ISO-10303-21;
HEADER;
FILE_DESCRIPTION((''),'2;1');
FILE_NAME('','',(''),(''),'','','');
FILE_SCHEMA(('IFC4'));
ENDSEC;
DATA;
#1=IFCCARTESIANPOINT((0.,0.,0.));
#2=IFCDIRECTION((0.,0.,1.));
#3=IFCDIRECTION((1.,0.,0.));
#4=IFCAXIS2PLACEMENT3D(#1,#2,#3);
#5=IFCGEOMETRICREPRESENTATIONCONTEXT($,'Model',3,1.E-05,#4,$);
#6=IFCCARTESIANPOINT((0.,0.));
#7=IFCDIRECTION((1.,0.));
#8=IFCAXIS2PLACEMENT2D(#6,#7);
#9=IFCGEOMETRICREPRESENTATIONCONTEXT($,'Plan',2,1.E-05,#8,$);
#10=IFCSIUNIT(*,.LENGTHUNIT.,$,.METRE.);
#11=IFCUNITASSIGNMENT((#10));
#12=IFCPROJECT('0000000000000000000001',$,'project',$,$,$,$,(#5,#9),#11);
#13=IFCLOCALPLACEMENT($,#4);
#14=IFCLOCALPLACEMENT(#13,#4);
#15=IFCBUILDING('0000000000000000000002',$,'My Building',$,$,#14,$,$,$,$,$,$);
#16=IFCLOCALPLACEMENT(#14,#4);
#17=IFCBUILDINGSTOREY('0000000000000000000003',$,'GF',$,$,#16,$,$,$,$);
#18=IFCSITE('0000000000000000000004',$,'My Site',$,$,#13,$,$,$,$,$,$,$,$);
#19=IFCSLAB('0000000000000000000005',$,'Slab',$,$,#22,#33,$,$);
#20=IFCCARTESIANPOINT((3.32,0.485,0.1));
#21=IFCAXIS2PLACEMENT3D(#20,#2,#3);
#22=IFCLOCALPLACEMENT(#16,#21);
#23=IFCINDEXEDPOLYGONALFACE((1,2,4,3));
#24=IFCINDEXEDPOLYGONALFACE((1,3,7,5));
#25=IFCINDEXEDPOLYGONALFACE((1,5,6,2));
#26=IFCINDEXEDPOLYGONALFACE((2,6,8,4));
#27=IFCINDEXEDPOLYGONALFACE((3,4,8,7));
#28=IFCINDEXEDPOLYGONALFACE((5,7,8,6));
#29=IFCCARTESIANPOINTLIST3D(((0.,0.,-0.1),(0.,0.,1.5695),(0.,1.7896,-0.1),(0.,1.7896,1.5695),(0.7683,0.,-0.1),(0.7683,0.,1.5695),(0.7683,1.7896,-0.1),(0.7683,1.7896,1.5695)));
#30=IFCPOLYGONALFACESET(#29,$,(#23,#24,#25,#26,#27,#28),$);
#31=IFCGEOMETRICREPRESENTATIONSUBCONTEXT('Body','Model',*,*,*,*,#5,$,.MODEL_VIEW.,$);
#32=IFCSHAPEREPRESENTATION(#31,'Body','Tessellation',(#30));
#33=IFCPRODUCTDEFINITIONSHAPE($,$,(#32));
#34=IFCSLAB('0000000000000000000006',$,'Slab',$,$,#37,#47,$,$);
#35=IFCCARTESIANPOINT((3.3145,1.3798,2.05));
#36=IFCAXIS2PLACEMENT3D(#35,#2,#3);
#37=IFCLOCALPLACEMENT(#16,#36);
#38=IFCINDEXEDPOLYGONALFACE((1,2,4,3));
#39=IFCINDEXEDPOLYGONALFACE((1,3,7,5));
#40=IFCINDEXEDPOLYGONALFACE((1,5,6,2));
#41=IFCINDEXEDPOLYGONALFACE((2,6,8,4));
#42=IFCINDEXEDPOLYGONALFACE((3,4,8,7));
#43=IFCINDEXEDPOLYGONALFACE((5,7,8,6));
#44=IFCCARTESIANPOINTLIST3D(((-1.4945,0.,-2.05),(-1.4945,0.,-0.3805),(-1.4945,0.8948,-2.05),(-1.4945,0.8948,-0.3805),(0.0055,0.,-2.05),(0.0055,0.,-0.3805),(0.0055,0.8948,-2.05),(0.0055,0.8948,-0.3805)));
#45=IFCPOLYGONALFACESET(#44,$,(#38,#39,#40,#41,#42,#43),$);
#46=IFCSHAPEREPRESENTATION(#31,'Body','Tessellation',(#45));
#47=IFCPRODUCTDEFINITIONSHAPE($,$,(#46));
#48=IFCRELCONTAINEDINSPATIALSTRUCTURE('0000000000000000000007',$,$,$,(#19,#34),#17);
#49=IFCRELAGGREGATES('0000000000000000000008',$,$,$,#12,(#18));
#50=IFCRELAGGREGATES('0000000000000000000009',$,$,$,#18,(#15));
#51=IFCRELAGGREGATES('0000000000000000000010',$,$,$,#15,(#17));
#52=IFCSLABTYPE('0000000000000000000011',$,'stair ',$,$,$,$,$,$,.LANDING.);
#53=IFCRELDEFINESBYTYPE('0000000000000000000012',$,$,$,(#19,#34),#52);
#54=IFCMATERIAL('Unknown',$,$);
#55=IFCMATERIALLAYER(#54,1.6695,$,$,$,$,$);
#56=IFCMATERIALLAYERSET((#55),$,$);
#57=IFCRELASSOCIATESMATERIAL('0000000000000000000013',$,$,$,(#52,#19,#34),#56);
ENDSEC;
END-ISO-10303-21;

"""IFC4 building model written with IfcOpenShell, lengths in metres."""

from ifc_helpers import new_model, si_unit, frame, origin_with_axes, origin_2d_with_axis, place, context, subcontext, project, spatial, indexed_curve, outline, extrude, material, layer, layer_set, layer_usage, type_object, element, save


model = new_model("IFC4")

# Units and contexts
model_context = context("Model", 3, precision=1e-05, world=origin_with_axes())
plan_context = context("Plan", 2, precision=1e-05, world=origin_2d_with_axis())
body_context_1 = subcontext(model_context, "Body", "Model", "MODEL_VIEW")
ifc_project = project(units=[si_unit("LENGTHUNIT", "METRE")], contexts=[model_context, plan_context])

# Site, building, storey
site_placement = place(None, origin_with_axes())
site = spatial("IfcSite", under=ifc_project, at=site_placement, Name="My Site")
building_placement = place(site_placement, origin_with_axes())
building = spatial("IfcBuilding", under=site, at=building_placement, Name="My Building")
storey_placement = place(building_placement, origin_with_axes())
storey = spatial("IfcBuildingStorey", under=building, at=storey_placement, Name="GF")

# Shared definitions
ifc_material = material(Name="Unknown")

# Slabs
ifc_layer_1 = layer(ifc_material, 1.6695)
ifc_layer_set_1 = layer_set([ifc_layer_1])
ifc_layer_usage_1 = layer_usage(ifc_layer_set_1, "AXIS3", "POSITIVE", -0.1)
slab_type_1 = type_object("IfcSlabType", Name="stair ", PredefinedType="LANDING", material=ifc_layer_set_1)
slab_1_placement = place(storey_placement, frame((3.32, 0.485, 0.1), z_axis=(0.0, 0.0, 1.0), x_axis=(1.0, 0.0, 0.0)))
element("IfcSlab", 1, at=slab_1_placement, inside=storey, type_object=slab_type_1, material=ifc_layer_usage_1, Name="Slab", context=body_context_1, shape_type="SweptSolid", body=[
    extrude(outline(indexed_curve([(0.0, 0.0), (0.7683, 0.0), (0.7683, 1.7896), (0.0, 1.7896), (0.0, 0.0)])), frame((0.0, 0.0, -0.1), z_axis=(0.0, 0.0, 1.0), x_axis=(1.0, 0.0, 0.0)), (0.0, 0.0, 1.0), 1.6695),
])
ifc_layer_usage_2 = layer_usage(ifc_layer_set_1, "AXIS3", "POSITIVE", -2.05)
slab_2_placement = place(storey_placement, frame((3.3145, 1.3798, 2.05), z_axis=(0.0, 0.0, 1.0), x_axis=(1.0, 0.0, 0.0)))
element("IfcSlab", 2, at=slab_2_placement, inside=storey, type_object=slab_type_1, material=ifc_layer_usage_2, Name="Slab", context=body_context_1, shape_type="SweptSolid", body=[
    extrude(outline(indexed_curve([(-1.4945, 0.0), (-1.4945, 0.8948), (0.0055, 0.8948), (0.0055, 0.0), (-1.4945, 0.0)])), frame((0.0, 0.0, -2.05), z_axis=(0.0, 0.0, 1.0), x_axis=(1.0, 0.0, 0.0)), (0.0, 0.0, 1.0), 1.6695),
])

save(model, "model.ifc")
